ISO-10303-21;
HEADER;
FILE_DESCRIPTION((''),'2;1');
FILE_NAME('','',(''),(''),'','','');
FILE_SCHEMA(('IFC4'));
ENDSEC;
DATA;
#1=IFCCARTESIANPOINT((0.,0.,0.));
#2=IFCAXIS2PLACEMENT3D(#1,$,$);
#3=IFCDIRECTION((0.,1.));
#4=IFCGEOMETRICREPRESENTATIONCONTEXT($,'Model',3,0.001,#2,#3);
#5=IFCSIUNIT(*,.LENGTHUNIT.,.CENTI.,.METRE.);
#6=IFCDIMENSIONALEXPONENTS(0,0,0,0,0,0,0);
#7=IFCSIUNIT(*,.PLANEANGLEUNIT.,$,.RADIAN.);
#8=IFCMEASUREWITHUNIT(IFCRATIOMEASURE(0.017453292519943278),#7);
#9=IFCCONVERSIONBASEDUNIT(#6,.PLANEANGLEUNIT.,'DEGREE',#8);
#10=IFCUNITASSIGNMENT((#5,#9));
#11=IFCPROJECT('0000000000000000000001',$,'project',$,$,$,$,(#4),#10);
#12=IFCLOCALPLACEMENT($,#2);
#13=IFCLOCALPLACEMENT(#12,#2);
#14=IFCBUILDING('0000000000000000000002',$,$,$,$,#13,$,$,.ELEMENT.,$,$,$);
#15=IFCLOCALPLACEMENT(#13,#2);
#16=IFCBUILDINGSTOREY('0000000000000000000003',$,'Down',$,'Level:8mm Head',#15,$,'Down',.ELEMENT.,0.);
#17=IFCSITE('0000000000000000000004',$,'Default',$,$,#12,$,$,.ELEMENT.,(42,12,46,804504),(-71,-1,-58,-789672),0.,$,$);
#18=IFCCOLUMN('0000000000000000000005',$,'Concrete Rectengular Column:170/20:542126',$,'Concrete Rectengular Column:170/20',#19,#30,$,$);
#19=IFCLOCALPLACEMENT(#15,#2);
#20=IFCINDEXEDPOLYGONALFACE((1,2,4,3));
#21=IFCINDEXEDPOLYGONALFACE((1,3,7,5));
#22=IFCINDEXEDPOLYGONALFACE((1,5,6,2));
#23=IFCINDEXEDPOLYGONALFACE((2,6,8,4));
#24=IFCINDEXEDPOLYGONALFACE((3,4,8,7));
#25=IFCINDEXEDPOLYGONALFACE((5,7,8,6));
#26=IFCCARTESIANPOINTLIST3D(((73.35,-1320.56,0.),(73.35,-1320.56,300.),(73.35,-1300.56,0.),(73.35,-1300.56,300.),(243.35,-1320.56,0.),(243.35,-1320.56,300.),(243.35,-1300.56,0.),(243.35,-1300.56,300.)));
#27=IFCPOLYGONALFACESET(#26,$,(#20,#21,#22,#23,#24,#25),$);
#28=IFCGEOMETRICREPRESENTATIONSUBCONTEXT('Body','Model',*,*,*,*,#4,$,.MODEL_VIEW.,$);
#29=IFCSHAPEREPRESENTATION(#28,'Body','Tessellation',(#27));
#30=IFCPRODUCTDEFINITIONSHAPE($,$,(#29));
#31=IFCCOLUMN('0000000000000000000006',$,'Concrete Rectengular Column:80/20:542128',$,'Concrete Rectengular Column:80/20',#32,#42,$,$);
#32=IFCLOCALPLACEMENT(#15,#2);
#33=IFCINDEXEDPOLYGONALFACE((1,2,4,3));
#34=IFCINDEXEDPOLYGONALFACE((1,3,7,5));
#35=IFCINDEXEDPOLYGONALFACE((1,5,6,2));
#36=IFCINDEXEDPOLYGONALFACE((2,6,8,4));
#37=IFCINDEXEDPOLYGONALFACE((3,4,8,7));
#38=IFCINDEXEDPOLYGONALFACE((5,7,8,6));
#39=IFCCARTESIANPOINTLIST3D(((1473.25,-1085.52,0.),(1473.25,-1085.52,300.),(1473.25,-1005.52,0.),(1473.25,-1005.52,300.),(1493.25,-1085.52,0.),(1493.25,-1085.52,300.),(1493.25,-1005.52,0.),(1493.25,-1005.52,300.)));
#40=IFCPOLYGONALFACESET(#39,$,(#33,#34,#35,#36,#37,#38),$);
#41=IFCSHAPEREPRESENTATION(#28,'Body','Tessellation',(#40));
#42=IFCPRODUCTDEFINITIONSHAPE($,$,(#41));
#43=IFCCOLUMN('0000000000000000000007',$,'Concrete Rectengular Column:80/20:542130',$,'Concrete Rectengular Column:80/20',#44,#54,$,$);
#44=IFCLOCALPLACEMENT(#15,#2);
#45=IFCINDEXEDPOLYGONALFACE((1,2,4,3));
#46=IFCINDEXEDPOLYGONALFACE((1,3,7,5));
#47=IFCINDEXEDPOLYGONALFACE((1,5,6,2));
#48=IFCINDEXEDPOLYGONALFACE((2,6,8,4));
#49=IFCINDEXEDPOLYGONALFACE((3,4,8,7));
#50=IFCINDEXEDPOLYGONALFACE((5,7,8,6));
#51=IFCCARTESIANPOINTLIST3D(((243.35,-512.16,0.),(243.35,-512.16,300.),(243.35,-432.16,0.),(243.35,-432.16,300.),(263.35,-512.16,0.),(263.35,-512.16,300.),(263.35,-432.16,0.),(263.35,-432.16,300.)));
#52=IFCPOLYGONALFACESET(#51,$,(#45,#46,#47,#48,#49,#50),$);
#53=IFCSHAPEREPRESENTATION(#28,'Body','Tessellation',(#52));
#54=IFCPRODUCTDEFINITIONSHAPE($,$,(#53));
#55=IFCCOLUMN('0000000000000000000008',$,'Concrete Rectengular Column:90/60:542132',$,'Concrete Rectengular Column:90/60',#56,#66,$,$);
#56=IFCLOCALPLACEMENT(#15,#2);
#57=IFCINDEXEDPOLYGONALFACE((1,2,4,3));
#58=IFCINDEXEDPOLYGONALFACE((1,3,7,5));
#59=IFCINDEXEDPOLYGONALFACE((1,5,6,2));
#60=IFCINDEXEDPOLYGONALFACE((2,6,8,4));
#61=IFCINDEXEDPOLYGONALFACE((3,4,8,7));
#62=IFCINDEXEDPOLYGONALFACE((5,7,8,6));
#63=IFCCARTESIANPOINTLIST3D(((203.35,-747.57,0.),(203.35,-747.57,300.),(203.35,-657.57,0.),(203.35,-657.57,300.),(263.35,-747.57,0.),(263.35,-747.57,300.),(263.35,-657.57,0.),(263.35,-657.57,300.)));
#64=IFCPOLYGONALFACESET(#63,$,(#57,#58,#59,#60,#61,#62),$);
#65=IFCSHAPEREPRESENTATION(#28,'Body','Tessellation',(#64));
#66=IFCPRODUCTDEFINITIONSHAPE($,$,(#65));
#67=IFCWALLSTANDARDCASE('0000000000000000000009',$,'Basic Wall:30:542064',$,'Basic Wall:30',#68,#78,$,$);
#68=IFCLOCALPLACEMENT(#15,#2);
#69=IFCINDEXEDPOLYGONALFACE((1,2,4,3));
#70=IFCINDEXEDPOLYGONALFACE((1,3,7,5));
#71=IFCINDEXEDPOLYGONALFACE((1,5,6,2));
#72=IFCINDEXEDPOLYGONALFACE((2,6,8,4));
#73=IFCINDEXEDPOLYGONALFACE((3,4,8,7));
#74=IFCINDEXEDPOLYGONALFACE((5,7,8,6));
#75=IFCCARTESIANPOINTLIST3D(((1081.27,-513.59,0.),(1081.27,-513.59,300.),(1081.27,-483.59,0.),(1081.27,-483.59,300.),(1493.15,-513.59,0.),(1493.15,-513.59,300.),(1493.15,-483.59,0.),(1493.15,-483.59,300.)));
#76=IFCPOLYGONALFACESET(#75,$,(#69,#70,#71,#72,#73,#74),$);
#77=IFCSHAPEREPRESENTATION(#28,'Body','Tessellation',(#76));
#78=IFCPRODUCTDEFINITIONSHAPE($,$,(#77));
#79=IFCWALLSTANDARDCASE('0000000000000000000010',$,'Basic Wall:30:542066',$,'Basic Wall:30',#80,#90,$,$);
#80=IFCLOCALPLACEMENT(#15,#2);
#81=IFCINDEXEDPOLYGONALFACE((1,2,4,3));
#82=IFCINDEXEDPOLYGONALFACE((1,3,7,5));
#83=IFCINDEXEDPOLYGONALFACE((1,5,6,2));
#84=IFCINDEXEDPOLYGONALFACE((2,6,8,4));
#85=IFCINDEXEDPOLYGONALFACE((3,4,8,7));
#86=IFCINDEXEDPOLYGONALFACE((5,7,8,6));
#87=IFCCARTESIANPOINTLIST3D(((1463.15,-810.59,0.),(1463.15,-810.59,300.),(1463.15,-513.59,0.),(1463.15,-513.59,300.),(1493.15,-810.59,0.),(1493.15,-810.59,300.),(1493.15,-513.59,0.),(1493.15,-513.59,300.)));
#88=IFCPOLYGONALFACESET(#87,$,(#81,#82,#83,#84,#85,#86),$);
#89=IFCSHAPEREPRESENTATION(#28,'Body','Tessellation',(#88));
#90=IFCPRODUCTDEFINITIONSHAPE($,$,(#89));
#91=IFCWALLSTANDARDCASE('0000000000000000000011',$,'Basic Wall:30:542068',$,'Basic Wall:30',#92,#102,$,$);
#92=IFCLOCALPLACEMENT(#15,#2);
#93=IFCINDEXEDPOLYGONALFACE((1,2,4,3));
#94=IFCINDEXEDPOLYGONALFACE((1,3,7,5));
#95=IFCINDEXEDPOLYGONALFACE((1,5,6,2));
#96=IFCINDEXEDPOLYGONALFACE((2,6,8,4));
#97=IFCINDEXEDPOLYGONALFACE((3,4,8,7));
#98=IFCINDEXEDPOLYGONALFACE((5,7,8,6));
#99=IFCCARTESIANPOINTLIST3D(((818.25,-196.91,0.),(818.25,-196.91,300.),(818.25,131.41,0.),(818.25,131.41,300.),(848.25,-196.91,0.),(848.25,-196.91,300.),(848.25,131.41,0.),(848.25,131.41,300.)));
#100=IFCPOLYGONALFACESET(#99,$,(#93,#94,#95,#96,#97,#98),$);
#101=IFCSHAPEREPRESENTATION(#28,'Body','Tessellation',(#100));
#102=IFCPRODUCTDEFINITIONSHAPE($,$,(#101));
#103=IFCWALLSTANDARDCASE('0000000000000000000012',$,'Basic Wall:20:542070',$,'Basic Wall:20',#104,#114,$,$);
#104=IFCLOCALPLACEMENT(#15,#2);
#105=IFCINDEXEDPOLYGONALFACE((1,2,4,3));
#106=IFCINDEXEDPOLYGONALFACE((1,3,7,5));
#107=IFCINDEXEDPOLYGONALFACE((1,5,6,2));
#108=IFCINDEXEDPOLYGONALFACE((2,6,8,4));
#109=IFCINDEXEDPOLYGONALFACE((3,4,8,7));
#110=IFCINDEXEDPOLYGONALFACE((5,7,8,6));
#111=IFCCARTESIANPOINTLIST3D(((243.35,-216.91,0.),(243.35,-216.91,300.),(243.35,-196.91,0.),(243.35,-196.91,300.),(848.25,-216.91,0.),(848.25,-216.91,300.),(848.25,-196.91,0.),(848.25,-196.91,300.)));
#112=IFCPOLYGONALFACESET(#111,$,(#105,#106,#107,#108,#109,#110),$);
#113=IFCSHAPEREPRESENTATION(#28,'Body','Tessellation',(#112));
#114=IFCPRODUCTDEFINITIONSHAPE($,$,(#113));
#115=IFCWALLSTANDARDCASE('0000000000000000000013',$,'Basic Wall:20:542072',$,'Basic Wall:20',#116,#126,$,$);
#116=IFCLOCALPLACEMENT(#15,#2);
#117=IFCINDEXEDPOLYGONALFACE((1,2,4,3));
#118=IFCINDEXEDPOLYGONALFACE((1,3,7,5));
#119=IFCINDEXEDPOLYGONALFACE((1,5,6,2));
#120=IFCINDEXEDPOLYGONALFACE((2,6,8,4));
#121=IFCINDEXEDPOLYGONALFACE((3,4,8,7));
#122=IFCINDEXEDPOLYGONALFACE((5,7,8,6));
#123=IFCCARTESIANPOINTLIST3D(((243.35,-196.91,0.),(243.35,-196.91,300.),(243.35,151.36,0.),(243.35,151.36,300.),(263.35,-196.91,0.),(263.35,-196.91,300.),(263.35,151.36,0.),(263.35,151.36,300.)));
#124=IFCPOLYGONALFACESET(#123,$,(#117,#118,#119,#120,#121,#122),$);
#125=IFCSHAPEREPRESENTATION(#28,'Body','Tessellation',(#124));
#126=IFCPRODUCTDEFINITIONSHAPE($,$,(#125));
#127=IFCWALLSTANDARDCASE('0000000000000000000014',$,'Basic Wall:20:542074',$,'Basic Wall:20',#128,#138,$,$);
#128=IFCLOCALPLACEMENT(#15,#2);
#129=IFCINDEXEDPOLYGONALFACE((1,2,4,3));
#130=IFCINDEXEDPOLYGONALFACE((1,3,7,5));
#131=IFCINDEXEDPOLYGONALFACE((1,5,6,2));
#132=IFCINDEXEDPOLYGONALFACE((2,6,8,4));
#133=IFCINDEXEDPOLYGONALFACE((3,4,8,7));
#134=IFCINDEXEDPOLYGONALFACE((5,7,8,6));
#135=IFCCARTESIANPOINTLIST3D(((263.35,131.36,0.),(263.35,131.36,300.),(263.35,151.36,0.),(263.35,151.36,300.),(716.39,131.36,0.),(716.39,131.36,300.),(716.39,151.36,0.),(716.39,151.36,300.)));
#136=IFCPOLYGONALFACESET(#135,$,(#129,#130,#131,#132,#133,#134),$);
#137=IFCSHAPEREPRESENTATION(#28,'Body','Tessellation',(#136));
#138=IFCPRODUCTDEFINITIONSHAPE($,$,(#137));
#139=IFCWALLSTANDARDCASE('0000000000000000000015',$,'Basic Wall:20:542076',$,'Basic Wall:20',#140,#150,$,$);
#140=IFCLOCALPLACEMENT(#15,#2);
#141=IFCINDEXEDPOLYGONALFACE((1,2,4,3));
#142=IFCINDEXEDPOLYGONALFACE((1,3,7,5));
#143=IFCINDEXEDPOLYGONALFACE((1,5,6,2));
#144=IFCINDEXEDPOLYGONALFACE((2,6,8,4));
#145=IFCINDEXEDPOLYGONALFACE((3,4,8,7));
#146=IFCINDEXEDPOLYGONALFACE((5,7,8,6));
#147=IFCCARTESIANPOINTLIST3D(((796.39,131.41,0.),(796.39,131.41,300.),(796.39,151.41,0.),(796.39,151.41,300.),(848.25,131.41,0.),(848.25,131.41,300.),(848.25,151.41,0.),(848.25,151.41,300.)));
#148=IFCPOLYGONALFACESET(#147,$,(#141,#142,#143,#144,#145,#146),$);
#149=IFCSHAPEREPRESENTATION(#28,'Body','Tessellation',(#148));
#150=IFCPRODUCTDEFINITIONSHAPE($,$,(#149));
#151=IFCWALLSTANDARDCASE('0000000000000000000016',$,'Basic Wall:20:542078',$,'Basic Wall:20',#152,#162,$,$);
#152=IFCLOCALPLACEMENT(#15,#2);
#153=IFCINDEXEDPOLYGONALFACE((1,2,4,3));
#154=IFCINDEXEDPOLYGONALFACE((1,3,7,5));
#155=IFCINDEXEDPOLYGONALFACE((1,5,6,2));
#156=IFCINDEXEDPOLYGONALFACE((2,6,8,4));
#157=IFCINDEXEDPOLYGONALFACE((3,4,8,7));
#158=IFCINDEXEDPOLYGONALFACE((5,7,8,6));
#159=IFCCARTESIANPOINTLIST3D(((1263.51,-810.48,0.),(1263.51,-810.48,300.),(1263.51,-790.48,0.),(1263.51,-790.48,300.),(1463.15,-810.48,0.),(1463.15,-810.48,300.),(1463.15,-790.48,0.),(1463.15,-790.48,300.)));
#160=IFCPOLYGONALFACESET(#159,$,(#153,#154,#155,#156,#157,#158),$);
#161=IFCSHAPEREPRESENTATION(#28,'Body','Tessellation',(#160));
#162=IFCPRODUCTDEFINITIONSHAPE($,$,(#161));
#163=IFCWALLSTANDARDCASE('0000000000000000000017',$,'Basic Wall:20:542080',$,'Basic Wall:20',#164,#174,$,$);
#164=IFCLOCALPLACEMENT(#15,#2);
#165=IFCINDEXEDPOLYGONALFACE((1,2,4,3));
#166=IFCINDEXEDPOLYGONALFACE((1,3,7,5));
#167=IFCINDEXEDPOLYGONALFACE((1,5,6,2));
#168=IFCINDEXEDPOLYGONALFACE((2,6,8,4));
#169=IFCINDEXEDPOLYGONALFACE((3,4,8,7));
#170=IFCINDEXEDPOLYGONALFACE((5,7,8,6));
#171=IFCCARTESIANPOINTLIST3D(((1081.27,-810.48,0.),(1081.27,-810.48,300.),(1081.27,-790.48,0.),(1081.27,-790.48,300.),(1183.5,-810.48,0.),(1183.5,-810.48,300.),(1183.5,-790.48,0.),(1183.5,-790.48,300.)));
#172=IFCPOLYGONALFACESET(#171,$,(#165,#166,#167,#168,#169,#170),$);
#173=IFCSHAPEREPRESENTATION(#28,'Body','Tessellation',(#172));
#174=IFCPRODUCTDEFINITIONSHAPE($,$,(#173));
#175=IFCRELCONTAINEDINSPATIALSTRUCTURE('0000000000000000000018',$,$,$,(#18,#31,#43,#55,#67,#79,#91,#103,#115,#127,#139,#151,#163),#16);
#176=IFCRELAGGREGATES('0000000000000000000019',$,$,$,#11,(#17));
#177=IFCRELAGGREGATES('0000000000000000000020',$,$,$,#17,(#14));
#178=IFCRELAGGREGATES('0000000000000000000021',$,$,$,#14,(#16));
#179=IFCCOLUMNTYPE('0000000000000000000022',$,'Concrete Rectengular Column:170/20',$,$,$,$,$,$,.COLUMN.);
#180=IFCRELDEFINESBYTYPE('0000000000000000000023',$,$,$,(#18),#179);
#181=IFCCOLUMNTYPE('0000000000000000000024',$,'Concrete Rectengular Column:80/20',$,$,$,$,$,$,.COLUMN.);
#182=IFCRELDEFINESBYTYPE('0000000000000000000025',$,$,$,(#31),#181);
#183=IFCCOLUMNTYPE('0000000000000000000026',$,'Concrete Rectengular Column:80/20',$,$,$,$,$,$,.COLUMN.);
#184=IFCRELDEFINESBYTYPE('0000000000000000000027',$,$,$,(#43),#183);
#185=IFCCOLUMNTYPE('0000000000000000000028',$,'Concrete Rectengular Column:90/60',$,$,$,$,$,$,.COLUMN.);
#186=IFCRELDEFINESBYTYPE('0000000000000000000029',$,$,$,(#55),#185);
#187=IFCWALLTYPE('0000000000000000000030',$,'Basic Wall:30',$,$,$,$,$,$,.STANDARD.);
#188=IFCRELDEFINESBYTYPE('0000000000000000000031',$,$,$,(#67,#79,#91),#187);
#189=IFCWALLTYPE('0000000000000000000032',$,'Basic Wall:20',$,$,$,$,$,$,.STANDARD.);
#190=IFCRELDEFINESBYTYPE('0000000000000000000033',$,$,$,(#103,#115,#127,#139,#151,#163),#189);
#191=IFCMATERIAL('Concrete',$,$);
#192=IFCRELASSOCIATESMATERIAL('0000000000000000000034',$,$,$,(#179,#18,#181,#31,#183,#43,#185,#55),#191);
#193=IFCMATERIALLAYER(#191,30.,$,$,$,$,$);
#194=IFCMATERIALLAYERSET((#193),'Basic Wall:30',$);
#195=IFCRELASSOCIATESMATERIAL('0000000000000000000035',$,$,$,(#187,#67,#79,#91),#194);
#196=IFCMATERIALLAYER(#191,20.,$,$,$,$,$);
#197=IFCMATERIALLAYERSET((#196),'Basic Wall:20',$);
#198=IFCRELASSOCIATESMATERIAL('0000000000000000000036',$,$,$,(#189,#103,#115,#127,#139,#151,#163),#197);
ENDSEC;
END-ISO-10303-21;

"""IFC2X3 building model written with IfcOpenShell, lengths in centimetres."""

from ifc_helpers import new_model, entity, si_unit, converted_unit, direction, frame, frame_2d, origin, place, context, subcontext, project, spatial, rectangle, extrude, source, transform, mapped, material, layer, layer_set, layer_usage, type_object, type_shapes, element, save


model = new_model("IFC2X3")

# Units and contexts
model_context = context("Model", 3, precision=0.001, world=origin(), true_north=direction((0.0, 1.0)))
body_context = subcontext(model_context, "Body", "Model", "MODEL_VIEW")
ifc_project = project(units=[si_unit("LENGTHUNIT", "METRE", prefix="CENTI"), converted_unit("PLANEANGLEUNIT", "DEGREE", entity("IfcRatioMeasure", 0.017453292519943278), si_unit("PLANEANGLEUNIT", "RADIAN"), dimensions=[0, 0, 0, 0, 0, 0, 0])], contexts=[model_context])

# Site, building, storey
site_placement = place(None, origin())
site = spatial("IfcSite", under=ifc_project, at=site_placement, Name="Default", CompositionType="ELEMENT", RefLatitude=(42, 12, 46, 804504), RefLongitude=(-71, -1, -58, -789672), RefElevation=0.0)
building_placement = place(site_placement, origin())
building = spatial("IfcBuilding", under=site, at=building_placement, CompositionType="ELEMENT")
storey_placement = place(building_placement, origin())
storey = spatial("IfcBuildingStorey", under=building, at=storey_placement, Name="Down", ObjectType="Level:8mm Head", LongName="Down", CompositionType="ELEMENT", Elevation=0.0)

# Columns
ifc_material = material(Name="Concrete")
column_type_1 = type_object("IfcColumnType", Name="Concrete Rectengular Column:170/20", PredefinedType="COLUMN", material=ifc_material)
shared_shape_1 = source(origin(), body_context, "Body", "SweptSolid", [
    extrude(rectangle(XDim=20.0, YDim=170.0, at=frame_2d((0.0, 0.0), x_axis=(1.0, 0.0))), frame((158.35, -1310.56, 0.0), z_axis=(0.0, 0.0, 1.0), x_axis=(0.0, -1.0, 0.0)), (0.0, 0.0, 1.0), 300.0),
])
type_shapes(column_type_1, [shared_shape_1])
column_1_placement = place(storey_placement, origin())
element("IfcColumn", 1, at=column_1_placement, inside=storey, type_object=column_type_1, material=ifc_material, Name="Concrete Rectengular Column:170/20:542126", ObjectType="Concrete Rectengular Column:170/20", context=body_context, shape_type="MappedRepresentation", body=[
    mapped(shared_shape_1, transform((0.0, 0.0, 0.0), scale=1.0)),
])
column_type_2 = type_object("IfcColumnType", Name="Concrete Rectengular Column:80/20", PredefinedType="COLUMN", material=ifc_material)
shared_shape_2 = source(origin(), body_context, "Body", "SweptSolid", [
    extrude(rectangle(XDim=80.0, YDim=20.0, at=frame_2d((0.0, 0.0), x_axis=(1.0, 0.0))), frame((1483.25, -1045.52, 0.0), z_axis=(0.0, 0.0, 1.0), x_axis=(0.0, -1.0, 0.0)), (0.0, 0.0, 1.0), 300.0),
])
type_shapes(column_type_2, [shared_shape_2])
column_2_placement = place(storey_placement, origin())
element("IfcColumn", 2, at=column_2_placement, inside=storey, type_object=column_type_2, material=ifc_material, Name="Concrete Rectengular Column:80/20:542128", ObjectType="Concrete Rectengular Column:80/20", context=body_context, shape_type="MappedRepresentation", body=[
    mapped(shared_shape_2, transform((0.0, 0.0, 0.0), scale=1.0)),
])
column_type_3 = type_object("IfcColumnType", Name="Concrete Rectengular Column:80/20", PredefinedType="COLUMN", material=ifc_material)
shared_shape_3 = source(origin(), body_context, "Body", "SweptSolid", [
    extrude(rectangle(XDim=80.0, YDim=20.0, at=frame_2d((0.0, 0.0), x_axis=(1.0, 0.0))), frame((253.35, -472.16, 0.0), z_axis=(0.0, 0.0, 1.0), x_axis=(0.0, -1.0, 0.0)), (0.0, 0.0, 1.0), 300.0),
])
type_shapes(column_type_3, [shared_shape_3])
column_3_placement = place(storey_placement, origin())
element("IfcColumn", 3, at=column_3_placement, inside=storey, type_object=column_type_3, material=ifc_material, Name="Concrete Rectengular Column:80/20:542130", ObjectType="Concrete Rectengular Column:80/20", context=body_context, shape_type="MappedRepresentation", body=[
    mapped(shared_shape_3, transform((0.0, 0.0, 0.0), scale=1.0)),
])
column_type_4 = type_object("IfcColumnType", Name="Concrete Rectengular Column:90/60", PredefinedType="COLUMN", material=ifc_material)
shared_shape_4 = source(origin(), body_context, "Body", "SweptSolid", [
    extrude(rectangle(XDim=90.0, YDim=60.0, at=frame_2d((0.0, 0.0), x_axis=(1.0, 0.0))), frame((233.35, -702.57, 0.0), z_axis=(0.0, 0.0, 1.0), x_axis=(0.0, -1.0, 0.0)), (0.0, 0.0, 1.0), 300.0),
])
type_shapes(column_type_4, [shared_shape_4])
column_4_placement = place(storey_placement, origin())
element("IfcColumn", 4, at=column_4_placement, inside=storey, type_object=column_type_4, material=ifc_material, Name="Concrete Rectengular Column:90/60:542132", ObjectType="Concrete Rectengular Column:90/60", context=body_context, shape_type="MappedRepresentation", body=[
    mapped(shared_shape_4, transform((0.0, 0.0, 0.0), scale=1.0)),
])

# Walls
ifc_layer_1 = layer(ifc_material, 30.0)
ifc_layer_set_1 = layer_set([ifc_layer_1], Name="Basic Wall:30")
ifc_layer_usage_1 = layer_usage(ifc_layer_set_1, "AXIS2", "POSITIVE", -15.0)
wall_type_1 = type_object("IfcWallType", Name="Basic Wall:30", PredefinedType="STANDARD", material=ifc_layer_set_1)
wall_1_placement = place(storey_placement, frame((1493.15, -498.59, 0.0), z_axis=(0.0, 0.0, 1.0), x_axis=(-1.0, 0.0, 0.0)))
element("IfcWallStandardCase", 5, at=wall_1_placement, inside=storey, type_object=wall_type_1, material=ifc_layer_usage_1, Name="Basic Wall:30:542064", ObjectType="Basic Wall:30", context=body_context, shape_type="SweptSolid", body=[
    extrude(rectangle(XDim=411.87, YDim=30.0, at=frame_2d((205.94, 0.0), x_axis=(-1.0, 0.0))), origin(), (0.0, 0.0, 1.0), 300.0),
])
ifc_layer_usage_2 = layer_usage(ifc_layer_set_1, "AXIS2", "NEGATIVE", 15.0)
wall_2_placement = place(storey_placement, frame((1478.15, -513.59, 0.0), z_axis=(0.0, 0.0, 1.0), x_axis=(0.0, -1.0, 0.0)))
element("IfcWallStandardCase", 6, at=wall_2_placement, inside=storey, type_object=wall_type_1, material=ifc_layer_usage_2, Name="Basic Wall:30:542066", ObjectType="Basic Wall:30", context=body_context, shape_type="SweptSolid", body=[
    extrude(rectangle(XDim=297.0, YDim=30.0, at=frame_2d((148.5, 0.0), x_axis=(-1.0, 0.0))), origin(), (0.0, 0.0, 1.0), 300.0),
])
ifc_layer_usage_3 = layer_usage(ifc_layer_set_1, "AXIS2", "POSITIVE", -15.0)
wall_3_placement = place(storey_placement, frame((833.25, -196.91, 0.0), z_axis=(0.0, 0.0, 1.0), x_axis=(0.0, 1.0, 0.0)))
element("IfcWallStandardCase", 7, at=wall_3_placement, inside=storey, type_object=wall_type_1, material=ifc_layer_usage_3, Name="Basic Wall:30:542068", ObjectType="Basic Wall:30", context=body_context, shape_type="SweptSolid", body=[
    extrude(rectangle(XDim=328.32, YDim=30.0, at=frame_2d((164.16, 0.0), x_axis=(-1.0, 0.0))), origin(), (0.0, 0.0, 1.0), 300.0),
])
ifc_layer_2 = layer(ifc_material, 20.0)
ifc_layer_set_2 = layer_set([ifc_layer_2], Name="Basic Wall:20")
ifc_layer_usage_4 = layer_usage(ifc_layer_set_2, "AXIS2", "NEGATIVE", 10.0)
wall_type_2 = type_object("IfcWallType", Name="Basic Wall:20", PredefinedType="STANDARD", material=ifc_layer_set_2)
wall_4_placement = place(storey_placement, frame((848.25, -206.91, 0.0), z_axis=(0.0, 0.0, 1.0), x_axis=(-1.0, 0.0, 0.0)))
element("IfcWallStandardCase", 8, at=wall_4_placement, inside=storey, type_object=wall_type_2, material=ifc_layer_usage_4, Name="Basic Wall:20:542070", ObjectType="Basic Wall:20", context=body_context, shape_type="SweptSolid", body=[
    extrude(rectangle(XDim=604.9, YDim=20.0, at=frame_2d((302.45, 0.0), x_axis=(-1.0, 0.0))), origin(), (0.0, 0.0, 1.0), 300.0),
])
ifc_layer_usage_5 = layer_usage(ifc_layer_set_2, "AXIS2", "NEGATIVE", 10.0)
wall_5_placement = place(storey_placement, frame((253.35, -196.91, 0.0), z_axis=(0.0, 0.0, 1.0), x_axis=(0.0, 1.0, 0.0)))
element("IfcWallStandardCase", 9, at=wall_5_placement, inside=storey, type_object=wall_type_2, material=ifc_layer_usage_5, Name="Basic Wall:20:542072", ObjectType="Basic Wall:20", context=body_context, shape_type="SweptSolid", body=[
    extrude(rectangle(XDim=348.27, YDim=20.0, at=frame_2d((174.14, 0.0), x_axis=(-1.0, 0.0))), origin(), (0.0, 0.0, 1.0), 300.0),
])
ifc_layer_usage_6 = layer_usage(ifc_layer_set_2, "AXIS2", "NEGATIVE", 10.0)
wall_6_placement = place(storey_placement, frame((263.35, 141.36, 0.0)))
element("IfcWallStandardCase", 10, at=wall_6_placement, inside=storey, type_object=wall_type_2, material=ifc_layer_usage_6, Name="Basic Wall:20:542074", ObjectType="Basic Wall:20", context=body_context, shape_type="SweptSolid", body=[
    extrude(rectangle(XDim=453.04, YDim=20.0, at=frame_2d((226.52, 0.0), x_axis=(-1.0, 0.0))), origin(), (0.0, 0.0, 1.0), 300.0),
])
ifc_layer_usage_7 = layer_usage(ifc_layer_set_2, "AXIS2", "NEGATIVE", 10.0)
wall_7_placement = place(storey_placement, frame((796.39, 141.41, 0.0)))
element("IfcWallStandardCase", 11, at=wall_7_placement, inside=storey, type_object=wall_type_2, material=ifc_layer_usage_7, Name="Basic Wall:20:542076", ObjectType="Basic Wall:20", context=body_context, shape_type="SweptSolid", body=[
    extrude(rectangle(XDim=51.85, YDim=20.0, at=frame_2d((25.93, 0.0), x_axis=(-1.0, 0.0))), origin(), (0.0, 0.0, 1.0), 300.0),
])
ifc_layer_usage_8 = layer_usage(ifc_layer_set_2, "AXIS2", "POSITIVE", -10.0)
wall_8_placement = place(storey_placement, frame((1463.15, -800.48, 0.0), z_axis=(0.0, 0.0, 1.0), x_axis=(-1.0, 0.0, 0.0)))
element("IfcWallStandardCase", 12, at=wall_8_placement, inside=storey, type_object=wall_type_2, material=ifc_layer_usage_8, Name="Basic Wall:20:542078", ObjectType="Basic Wall:20", context=body_context, shape_type="SweptSolid", body=[
    extrude(rectangle(XDim=199.64, YDim=20.0, at=frame_2d((99.82, 0.0), x_axis=(-1.0, 0.0))), origin(), (0.0, 0.0, 1.0), 300.0),
])
ifc_layer_usage_9 = layer_usage(ifc_layer_set_2, "AXIS2", "POSITIVE", -10.0)
wall_9_placement = place(storey_placement, frame((1183.5, -800.48, 0.0), z_axis=(0.0, 0.0, 1.0), x_axis=(-1.0, 0.0, 0.0)))
element("IfcWallStandardCase", 13, at=wall_9_placement, inside=storey, type_object=wall_type_2, material=ifc_layer_usage_9, Name="Basic Wall:20:542080", ObjectType="Basic Wall:20", context=body_context, shape_type="SweptSolid", body=[
    extrude(rectangle(XDim=102.23, YDim=20.0, at=frame_2d((51.11, 0.0), x_axis=(-1.0, 0.0))), origin(), (0.0, 0.0, 1.0), 300.0),
])

save(model, "model.ifc")
